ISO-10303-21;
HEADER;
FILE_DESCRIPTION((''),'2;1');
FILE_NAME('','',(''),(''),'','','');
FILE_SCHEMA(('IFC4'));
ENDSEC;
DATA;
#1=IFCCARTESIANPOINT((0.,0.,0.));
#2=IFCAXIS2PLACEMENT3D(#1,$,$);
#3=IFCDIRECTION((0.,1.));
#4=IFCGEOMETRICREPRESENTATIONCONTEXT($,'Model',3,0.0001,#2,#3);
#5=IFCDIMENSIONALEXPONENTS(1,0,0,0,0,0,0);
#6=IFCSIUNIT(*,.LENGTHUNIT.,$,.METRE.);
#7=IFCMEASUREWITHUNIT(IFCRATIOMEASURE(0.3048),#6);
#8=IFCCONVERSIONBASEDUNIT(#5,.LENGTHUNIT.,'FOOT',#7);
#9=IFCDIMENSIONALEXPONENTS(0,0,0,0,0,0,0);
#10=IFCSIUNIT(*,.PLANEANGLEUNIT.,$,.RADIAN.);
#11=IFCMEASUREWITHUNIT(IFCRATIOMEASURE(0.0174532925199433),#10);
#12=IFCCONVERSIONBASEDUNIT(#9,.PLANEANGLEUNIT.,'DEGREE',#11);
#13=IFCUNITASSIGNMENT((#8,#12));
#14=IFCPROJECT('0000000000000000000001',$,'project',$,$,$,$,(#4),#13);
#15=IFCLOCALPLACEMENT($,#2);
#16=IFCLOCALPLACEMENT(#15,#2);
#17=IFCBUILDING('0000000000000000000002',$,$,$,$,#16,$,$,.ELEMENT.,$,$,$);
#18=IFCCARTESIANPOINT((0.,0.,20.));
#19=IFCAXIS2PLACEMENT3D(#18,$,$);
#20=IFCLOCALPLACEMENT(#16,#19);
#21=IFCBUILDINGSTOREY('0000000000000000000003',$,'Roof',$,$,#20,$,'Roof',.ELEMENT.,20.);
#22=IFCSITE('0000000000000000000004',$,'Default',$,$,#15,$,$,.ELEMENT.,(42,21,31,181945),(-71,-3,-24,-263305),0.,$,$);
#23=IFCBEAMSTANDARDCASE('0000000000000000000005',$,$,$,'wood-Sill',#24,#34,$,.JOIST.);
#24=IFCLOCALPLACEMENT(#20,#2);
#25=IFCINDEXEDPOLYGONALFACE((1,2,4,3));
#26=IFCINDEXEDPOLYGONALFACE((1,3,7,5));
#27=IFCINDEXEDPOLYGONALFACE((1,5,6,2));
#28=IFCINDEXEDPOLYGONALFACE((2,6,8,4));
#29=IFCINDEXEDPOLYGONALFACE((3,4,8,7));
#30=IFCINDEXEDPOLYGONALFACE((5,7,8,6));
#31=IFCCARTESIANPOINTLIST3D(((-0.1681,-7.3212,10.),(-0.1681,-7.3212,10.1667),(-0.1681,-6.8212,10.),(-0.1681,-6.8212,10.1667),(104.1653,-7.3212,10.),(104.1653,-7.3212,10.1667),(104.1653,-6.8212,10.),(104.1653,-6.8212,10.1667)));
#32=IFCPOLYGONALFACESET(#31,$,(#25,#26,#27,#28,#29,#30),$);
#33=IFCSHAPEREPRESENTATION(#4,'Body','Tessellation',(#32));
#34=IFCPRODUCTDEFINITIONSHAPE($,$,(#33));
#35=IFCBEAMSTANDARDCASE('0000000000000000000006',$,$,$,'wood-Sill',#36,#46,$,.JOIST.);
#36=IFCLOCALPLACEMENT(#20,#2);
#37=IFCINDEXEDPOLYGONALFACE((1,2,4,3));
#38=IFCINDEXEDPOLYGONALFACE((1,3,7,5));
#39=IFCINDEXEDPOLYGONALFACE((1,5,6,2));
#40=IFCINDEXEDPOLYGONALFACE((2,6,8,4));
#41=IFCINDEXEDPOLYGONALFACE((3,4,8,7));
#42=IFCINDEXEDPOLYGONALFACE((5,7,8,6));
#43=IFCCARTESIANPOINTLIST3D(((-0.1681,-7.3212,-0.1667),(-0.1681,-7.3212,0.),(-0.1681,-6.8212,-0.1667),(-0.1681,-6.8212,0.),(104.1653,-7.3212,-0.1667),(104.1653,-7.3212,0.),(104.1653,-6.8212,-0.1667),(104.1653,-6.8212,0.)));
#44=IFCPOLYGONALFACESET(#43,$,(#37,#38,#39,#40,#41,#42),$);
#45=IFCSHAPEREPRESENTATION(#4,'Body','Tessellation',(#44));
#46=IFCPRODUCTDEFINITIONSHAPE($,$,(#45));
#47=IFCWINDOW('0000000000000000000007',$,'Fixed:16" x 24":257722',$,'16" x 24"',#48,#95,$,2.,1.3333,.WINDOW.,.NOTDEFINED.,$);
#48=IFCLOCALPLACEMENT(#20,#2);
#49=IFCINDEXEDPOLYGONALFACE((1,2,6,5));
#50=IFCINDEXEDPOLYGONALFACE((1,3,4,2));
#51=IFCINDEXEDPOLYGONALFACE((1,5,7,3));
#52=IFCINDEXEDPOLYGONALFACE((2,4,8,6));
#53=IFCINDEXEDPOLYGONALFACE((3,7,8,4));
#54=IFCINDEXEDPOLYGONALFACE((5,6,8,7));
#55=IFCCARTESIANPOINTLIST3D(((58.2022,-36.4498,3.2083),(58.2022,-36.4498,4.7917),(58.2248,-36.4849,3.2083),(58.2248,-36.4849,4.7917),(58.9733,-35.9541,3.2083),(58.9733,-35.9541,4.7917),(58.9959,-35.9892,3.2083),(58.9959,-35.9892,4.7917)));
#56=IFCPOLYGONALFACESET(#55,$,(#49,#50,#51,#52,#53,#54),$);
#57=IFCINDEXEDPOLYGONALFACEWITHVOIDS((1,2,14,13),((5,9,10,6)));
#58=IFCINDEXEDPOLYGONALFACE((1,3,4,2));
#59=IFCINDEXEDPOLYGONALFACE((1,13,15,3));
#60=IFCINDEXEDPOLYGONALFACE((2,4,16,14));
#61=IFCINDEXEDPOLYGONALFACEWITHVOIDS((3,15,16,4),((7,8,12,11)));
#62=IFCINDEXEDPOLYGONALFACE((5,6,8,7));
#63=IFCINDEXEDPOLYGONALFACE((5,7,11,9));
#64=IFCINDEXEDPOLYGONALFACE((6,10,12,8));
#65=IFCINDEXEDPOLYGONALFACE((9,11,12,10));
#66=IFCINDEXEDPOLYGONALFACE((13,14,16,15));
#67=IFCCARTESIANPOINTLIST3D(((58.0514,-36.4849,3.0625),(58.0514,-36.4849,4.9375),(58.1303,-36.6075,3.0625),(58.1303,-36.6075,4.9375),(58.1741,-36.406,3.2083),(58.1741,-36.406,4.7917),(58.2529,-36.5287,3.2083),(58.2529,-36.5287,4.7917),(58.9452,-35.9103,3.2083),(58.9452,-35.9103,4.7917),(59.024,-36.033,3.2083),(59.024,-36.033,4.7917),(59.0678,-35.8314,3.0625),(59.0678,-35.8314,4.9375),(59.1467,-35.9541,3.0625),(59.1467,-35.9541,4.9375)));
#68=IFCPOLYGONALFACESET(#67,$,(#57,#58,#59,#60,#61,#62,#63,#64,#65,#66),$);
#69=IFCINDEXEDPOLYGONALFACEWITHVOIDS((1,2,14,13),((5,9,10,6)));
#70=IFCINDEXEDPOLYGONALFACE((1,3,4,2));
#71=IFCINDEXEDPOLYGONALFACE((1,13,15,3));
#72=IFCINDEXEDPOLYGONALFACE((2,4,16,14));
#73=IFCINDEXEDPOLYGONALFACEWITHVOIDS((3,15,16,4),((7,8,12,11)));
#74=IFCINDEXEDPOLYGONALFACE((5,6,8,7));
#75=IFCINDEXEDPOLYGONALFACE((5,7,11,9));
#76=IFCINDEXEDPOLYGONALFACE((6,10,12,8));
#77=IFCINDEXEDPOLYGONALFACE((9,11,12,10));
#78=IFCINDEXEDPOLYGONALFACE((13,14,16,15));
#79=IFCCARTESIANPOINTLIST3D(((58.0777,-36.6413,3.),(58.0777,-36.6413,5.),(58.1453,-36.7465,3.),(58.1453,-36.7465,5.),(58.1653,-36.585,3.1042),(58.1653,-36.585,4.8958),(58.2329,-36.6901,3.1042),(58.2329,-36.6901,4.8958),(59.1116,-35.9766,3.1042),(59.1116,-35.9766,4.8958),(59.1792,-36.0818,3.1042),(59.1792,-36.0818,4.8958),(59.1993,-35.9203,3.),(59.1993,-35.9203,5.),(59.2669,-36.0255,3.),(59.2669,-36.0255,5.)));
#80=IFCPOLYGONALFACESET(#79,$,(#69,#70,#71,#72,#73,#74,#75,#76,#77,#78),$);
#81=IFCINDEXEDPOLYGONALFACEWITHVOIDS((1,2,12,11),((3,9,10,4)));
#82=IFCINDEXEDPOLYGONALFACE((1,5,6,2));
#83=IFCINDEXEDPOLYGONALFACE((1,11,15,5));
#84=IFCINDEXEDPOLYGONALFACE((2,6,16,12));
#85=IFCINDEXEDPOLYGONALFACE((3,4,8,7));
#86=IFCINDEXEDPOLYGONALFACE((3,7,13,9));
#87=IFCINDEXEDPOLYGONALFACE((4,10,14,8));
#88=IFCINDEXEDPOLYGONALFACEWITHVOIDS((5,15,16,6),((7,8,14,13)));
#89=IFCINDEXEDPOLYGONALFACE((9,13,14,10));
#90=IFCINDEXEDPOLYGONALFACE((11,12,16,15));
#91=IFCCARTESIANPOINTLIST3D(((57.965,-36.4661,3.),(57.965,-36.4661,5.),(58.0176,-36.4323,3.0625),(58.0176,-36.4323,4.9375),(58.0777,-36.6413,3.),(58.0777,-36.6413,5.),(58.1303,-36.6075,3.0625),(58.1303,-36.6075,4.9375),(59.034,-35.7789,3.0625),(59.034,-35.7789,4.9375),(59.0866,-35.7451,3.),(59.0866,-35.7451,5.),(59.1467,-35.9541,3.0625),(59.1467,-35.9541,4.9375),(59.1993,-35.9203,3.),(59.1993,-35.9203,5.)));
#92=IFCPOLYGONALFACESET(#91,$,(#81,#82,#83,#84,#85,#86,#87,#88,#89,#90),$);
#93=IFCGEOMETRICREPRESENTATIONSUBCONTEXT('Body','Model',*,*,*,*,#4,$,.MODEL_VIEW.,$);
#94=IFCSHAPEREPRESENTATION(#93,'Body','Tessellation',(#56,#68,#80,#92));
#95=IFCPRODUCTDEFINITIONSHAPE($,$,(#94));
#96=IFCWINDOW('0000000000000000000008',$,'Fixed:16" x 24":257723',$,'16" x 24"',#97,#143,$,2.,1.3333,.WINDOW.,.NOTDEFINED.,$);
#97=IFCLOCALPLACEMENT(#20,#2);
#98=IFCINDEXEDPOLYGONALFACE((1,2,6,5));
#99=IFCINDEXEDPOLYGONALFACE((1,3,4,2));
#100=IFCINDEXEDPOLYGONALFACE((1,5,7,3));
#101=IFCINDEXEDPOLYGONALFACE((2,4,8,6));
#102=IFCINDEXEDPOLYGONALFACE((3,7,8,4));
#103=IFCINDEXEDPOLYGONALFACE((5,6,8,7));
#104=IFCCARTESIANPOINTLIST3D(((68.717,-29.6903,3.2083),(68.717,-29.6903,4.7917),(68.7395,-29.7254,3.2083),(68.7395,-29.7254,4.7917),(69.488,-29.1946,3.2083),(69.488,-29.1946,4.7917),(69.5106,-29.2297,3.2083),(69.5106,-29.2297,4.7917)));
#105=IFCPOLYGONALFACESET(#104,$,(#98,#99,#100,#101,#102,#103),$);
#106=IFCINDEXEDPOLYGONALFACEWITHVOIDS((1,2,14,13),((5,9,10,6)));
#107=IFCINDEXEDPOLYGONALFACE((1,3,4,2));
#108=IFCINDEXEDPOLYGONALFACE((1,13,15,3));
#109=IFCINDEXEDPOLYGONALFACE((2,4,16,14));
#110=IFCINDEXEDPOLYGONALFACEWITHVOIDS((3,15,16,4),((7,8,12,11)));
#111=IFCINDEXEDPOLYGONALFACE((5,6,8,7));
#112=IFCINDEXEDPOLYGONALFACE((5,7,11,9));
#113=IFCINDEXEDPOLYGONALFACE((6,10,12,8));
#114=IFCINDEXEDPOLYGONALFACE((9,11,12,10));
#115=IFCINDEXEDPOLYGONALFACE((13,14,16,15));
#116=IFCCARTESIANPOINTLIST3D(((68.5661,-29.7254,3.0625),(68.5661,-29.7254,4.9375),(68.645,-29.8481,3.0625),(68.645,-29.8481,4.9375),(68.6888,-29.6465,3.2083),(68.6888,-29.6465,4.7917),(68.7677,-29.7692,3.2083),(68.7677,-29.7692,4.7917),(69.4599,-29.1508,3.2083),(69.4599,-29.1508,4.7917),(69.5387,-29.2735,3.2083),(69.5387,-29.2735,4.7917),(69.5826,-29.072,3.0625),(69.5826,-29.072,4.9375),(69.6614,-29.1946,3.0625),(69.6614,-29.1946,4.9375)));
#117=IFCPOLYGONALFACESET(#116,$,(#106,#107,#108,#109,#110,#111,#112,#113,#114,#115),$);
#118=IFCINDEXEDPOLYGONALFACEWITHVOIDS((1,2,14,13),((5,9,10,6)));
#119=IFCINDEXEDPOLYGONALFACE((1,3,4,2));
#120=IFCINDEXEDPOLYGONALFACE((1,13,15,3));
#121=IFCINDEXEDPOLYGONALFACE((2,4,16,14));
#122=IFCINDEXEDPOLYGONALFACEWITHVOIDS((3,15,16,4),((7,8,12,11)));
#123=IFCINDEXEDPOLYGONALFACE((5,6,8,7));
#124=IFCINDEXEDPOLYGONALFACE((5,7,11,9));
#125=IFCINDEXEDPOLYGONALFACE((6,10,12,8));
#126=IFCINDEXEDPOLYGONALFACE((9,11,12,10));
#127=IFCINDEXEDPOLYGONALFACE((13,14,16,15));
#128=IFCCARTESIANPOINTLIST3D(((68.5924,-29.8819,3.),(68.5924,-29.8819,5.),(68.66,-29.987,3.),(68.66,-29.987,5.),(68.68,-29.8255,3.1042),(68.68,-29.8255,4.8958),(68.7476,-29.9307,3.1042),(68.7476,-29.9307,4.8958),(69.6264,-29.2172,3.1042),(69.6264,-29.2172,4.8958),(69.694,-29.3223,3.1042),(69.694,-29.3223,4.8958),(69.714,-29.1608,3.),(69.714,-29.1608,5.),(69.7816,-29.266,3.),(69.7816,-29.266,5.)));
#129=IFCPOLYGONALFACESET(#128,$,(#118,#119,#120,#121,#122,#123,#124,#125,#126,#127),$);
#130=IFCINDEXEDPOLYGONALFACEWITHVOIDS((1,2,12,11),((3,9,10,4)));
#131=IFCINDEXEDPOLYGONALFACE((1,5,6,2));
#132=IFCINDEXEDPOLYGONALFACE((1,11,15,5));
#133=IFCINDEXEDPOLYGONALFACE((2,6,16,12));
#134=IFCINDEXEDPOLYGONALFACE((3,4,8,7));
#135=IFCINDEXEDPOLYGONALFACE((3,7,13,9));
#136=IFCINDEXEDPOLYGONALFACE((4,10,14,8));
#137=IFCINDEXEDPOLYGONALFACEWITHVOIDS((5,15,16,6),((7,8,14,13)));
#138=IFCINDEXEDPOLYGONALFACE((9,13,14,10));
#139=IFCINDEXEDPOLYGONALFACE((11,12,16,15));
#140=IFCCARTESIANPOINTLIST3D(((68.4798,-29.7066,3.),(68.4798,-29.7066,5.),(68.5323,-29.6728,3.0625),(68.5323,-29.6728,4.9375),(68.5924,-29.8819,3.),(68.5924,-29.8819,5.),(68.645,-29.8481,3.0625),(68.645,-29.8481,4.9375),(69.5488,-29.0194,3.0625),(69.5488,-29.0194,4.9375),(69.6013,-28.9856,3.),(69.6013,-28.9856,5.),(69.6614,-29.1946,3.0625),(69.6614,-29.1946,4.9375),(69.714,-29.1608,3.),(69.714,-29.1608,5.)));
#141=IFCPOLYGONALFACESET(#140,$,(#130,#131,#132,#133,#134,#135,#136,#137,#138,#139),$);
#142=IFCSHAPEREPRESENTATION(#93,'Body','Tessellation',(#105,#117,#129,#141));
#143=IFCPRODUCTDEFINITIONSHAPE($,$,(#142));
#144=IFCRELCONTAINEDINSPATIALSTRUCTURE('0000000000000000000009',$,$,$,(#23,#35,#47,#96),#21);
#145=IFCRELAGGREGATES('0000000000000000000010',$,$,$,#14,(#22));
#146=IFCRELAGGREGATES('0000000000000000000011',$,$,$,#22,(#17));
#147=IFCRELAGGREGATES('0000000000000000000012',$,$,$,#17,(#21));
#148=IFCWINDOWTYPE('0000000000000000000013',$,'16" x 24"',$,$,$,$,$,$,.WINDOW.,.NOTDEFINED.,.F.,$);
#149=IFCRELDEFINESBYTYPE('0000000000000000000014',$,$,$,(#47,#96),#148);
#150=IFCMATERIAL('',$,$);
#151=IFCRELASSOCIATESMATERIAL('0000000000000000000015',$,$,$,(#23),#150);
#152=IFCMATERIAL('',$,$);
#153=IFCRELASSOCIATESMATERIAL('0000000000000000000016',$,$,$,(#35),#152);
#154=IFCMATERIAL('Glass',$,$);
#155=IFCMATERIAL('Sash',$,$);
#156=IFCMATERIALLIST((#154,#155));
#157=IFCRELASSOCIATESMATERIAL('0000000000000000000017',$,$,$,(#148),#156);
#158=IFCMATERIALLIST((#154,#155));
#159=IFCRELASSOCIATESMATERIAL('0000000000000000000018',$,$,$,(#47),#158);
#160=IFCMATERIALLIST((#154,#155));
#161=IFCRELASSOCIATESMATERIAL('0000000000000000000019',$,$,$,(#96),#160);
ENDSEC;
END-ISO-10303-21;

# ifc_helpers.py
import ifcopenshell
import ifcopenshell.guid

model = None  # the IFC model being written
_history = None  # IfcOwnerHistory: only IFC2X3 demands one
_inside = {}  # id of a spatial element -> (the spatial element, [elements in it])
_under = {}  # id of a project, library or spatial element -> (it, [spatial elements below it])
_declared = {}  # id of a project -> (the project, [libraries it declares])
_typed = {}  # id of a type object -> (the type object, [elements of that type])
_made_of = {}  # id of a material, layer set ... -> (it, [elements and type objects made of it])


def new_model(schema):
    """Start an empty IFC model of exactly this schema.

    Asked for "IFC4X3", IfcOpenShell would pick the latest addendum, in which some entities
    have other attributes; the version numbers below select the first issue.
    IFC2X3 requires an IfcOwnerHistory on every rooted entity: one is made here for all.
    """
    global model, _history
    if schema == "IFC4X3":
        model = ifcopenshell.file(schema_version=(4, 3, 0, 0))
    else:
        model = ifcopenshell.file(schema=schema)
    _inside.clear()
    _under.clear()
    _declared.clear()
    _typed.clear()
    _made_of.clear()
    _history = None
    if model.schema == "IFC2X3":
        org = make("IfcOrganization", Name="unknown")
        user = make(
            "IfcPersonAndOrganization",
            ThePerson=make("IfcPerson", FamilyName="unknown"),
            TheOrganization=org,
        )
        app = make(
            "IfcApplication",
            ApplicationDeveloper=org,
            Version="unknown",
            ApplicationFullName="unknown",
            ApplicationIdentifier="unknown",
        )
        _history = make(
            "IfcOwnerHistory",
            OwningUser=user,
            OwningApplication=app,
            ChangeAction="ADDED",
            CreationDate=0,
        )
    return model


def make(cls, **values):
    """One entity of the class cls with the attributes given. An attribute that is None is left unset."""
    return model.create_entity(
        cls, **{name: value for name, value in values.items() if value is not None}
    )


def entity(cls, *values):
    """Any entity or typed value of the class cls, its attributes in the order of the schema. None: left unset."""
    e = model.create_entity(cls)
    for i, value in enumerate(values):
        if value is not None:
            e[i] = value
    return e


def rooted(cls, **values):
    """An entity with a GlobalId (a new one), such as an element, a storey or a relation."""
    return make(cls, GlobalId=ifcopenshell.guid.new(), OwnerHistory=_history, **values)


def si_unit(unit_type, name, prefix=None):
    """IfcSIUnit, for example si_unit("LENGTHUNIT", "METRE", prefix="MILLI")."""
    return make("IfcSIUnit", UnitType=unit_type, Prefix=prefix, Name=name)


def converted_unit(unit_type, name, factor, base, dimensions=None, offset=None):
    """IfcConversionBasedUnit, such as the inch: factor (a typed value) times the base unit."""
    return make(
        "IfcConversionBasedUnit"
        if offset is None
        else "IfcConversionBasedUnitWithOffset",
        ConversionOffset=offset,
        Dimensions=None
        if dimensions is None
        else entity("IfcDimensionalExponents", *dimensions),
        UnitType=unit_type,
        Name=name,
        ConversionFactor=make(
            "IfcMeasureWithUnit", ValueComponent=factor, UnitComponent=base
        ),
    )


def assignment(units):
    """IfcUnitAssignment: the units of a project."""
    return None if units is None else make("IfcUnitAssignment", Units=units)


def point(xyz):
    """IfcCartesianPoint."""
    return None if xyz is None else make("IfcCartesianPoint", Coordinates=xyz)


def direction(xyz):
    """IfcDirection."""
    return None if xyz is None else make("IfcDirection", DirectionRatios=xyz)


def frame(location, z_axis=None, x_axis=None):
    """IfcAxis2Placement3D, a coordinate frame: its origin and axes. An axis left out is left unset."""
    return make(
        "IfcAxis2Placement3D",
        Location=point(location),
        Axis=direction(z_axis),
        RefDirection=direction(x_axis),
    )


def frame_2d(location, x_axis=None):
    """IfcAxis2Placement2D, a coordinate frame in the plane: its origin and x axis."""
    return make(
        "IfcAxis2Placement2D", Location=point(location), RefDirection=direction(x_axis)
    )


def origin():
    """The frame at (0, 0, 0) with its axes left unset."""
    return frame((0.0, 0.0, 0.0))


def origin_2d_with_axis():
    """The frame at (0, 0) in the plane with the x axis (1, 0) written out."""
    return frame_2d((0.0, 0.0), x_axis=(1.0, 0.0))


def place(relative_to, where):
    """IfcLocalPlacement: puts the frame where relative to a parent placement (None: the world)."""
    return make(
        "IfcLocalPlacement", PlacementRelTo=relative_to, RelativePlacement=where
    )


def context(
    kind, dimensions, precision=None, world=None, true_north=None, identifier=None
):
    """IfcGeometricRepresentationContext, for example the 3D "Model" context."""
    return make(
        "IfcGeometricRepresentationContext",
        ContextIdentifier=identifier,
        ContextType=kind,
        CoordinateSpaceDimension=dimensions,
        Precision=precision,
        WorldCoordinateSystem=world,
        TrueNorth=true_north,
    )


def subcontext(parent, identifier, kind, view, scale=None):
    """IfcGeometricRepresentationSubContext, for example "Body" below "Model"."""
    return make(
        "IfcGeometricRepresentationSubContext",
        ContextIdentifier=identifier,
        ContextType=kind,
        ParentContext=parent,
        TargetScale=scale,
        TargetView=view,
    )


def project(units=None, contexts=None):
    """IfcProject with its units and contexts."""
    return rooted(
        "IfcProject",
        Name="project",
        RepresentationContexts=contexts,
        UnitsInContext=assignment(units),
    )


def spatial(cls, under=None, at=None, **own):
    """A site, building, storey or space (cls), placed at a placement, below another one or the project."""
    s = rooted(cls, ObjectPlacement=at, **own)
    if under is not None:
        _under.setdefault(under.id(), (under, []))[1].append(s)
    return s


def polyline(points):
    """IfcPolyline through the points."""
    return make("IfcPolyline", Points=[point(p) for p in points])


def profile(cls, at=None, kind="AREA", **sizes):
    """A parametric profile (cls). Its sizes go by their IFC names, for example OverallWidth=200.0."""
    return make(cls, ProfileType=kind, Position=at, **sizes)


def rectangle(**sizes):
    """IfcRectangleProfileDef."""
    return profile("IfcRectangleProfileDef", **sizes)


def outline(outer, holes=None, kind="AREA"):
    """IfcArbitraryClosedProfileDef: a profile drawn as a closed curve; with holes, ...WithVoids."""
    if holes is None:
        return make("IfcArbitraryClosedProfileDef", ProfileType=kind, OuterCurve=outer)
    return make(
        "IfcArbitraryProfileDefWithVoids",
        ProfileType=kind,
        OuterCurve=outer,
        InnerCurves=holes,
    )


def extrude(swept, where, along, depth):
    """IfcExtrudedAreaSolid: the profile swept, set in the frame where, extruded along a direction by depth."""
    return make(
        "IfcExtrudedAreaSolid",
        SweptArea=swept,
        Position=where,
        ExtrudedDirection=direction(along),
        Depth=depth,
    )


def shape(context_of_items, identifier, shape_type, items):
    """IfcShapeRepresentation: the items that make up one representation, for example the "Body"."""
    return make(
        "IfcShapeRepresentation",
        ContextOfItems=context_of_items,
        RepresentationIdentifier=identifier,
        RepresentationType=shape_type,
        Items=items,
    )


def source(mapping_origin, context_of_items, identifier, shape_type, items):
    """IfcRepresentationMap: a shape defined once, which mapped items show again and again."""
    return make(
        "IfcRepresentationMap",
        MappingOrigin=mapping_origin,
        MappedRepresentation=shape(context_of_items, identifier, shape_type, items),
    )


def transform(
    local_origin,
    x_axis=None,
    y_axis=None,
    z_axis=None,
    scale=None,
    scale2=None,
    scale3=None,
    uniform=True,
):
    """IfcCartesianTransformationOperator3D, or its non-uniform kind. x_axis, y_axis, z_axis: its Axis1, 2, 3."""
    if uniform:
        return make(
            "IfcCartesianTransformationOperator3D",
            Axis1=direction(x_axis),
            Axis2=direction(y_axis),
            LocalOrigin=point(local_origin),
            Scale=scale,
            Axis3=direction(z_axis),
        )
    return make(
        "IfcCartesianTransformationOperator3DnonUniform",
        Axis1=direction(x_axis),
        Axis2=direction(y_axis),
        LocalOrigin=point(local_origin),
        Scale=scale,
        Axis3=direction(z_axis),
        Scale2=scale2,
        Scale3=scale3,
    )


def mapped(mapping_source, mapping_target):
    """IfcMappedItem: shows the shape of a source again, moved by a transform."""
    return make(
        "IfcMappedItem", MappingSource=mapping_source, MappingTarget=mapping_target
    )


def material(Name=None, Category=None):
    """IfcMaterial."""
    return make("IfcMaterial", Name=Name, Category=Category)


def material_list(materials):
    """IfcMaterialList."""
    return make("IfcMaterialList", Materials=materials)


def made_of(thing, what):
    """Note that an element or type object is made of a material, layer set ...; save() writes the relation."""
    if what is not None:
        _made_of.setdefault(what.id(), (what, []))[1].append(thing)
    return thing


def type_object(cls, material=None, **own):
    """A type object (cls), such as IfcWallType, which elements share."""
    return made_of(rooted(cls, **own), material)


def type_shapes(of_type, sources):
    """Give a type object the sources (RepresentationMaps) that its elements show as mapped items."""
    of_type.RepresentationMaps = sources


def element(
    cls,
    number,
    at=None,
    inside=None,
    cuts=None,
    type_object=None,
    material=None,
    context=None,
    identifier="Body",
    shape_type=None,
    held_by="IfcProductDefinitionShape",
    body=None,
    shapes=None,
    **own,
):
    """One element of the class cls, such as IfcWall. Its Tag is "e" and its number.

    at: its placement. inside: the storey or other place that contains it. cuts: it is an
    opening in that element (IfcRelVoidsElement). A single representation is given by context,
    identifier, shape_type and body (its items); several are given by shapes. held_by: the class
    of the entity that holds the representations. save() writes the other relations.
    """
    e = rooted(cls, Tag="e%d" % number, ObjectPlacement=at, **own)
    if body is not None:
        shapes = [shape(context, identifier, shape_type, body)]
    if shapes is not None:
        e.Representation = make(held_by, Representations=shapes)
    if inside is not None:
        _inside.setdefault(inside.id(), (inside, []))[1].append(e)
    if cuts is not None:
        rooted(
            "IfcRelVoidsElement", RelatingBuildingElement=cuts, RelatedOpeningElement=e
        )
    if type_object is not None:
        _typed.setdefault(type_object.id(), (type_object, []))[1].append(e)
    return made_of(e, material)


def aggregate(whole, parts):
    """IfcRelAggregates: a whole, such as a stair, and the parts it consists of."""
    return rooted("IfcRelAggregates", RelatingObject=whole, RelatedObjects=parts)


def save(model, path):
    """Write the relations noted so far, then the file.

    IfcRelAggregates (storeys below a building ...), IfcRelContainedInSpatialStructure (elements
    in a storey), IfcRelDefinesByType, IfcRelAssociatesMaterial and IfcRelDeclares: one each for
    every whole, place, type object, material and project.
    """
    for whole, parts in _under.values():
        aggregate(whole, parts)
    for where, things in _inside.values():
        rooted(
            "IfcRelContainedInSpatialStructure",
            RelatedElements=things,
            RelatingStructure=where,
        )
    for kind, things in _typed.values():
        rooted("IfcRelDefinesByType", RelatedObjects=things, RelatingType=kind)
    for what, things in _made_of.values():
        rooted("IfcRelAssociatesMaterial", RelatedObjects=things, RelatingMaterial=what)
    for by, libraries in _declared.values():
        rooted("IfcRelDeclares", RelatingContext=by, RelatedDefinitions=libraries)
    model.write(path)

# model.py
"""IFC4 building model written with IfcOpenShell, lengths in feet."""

from ifc_helpers import new_model, entity, si_unit, converted_unit, direction, frame, origin, origin_2d_with_axis, place, context, subcontext, project, spatial, polyline, rectangle, outline, extrude, source, transform, mapped, material, material_list, type_object, type_shapes, element, save


model = new_model("IFC4")

# Units and contexts
model_context = context("Model", 3, precision=0.0001, world=origin(), true_north=direction((0.0, 1.0)))
body_context = subcontext(model_context, "Body", "Model", "MODEL_VIEW")
ifc_project = project(units=[converted_unit("LENGTHUNIT", "FOOT", entity("IfcRatioMeasure", 0.3048), si_unit("LENGTHUNIT", "METRE"), dimensions=[1, 0, 0, 0, 0, 0, 0]), converted_unit("PLANEANGLEUNIT", "DEGREE", entity("IfcRatioMeasure", 0.0174532925199433), si_unit("PLANEANGLEUNIT", "RADIAN"), dimensions=[0, 0, 0, 0, 0, 0, 0])], contexts=[model_context])

# Site, building, storey
site_placement = place(None, origin())
site = spatial("IfcSite", under=ifc_project, at=site_placement, Name="Default", CompositionType="ELEMENT", RefLatitude=(42, 21, 31, 181945), RefLongitude=(-71, -3, -24, -263305), RefElevation=0.0)
building_placement = place(site_placement, origin())
building = spatial("IfcBuilding", under=site, at=building_placement, CompositionType="ELEMENT")
storey_placement = place(building_placement, frame((0.0, 0.0, 20.0)))
storey = spatial("IfcBuildingStorey", under=building, at=storey_placement, Name="Roof", LongName="Roof", CompositionType="ELEMENT", Elevation=20.0)

# Shared definitions
placement_1 = place(storey_placement, frame((104.1653, -7.0712, 0.0), z_axis=(0.0, 0.0, 1.0), x_axis=(-1.0, 0.0, 0.0)))

# Beams
ifc_material_1 = material(Name="")
beam_1_placement = place(placement_1, frame((52.1667, 0.0, 10.0), z_axis=(0.0, 0.0, 1.0), x_axis=(-1.0, 0.0, 0.0)))
element("IfcBeamStandardCase", 1, at=beam_1_placement, inside=storey, material=ifc_material_1, ObjectType="wood-Sill", PredefinedType="JOIST", context=model_context, shape_type="SweptSolid", body=[
    extrude(rectangle(XDim=104.3334, YDim=0.5), origin(), (0.0, 0.0, 1.0), 0.1667),
])
ifc_material_2 = material(Name="")
beam_2_placement = place(placement_1, frame((52.1667, 0.0, -0.1667), z_axis=(0.0, 0.0, 1.0), x_axis=(-1.0, 0.0, 0.0)))
element("IfcBeamStandardCase", 2, at=beam_2_placement, inside=storey, material=ifc_material_2, ObjectType="wood-Sill", PredefinedType="JOIST", context=model_context, shape_type="SweptSolid", body=[
    extrude(rectangle(XDim=104.3334, YDim=0.5), origin(), (0.0, 0.0, 1.0), 0.1667),
])

# Windows
ifc_material_3 = material(Name="Glass")
ifc_material_4 = material(Name="Sash")
ifc_material_list_1 = material_list([ifc_material_3, ifc_material_4])
ifc_material_list_2 = material_list([ifc_material_3, ifc_material_4])
window_type = type_object("IfcWindowType", Name="16\" x 24\"", ParameterTakesPrecedence=False, PartitioningType="NOTDEFINED", PredefinedType="WINDOW", material=ifc_material_list_2)
shared_shape = source(origin(), body_context, "Body", "SweptSolid", [
    extrude(rectangle(XDim=0.0417, YDim=0.9167, at=origin_2d_with_axis()), frame((0.6667, 0.1979, 0.2083), z_axis=(0.0, 0.0, 1.0), x_axis=(0.0, 1.0, 0.0)), (0.0, 0.0, 1.0), 1.5833),
    extrude(outline(polyline([(-0.6042, -0.9375), (0.6042, -0.9375), (0.6042, 0.9375), (-0.6042, 0.9375), (-0.6042, -0.9375)]), holes=[polyline([(-0.4583, -0.7917), (-0.4583, 0.7917), (0.4583, 0.7917), (0.4583, -0.7917), (-0.4583, -0.7917)])]), frame((0.6667, 0.125, 1.0), z_axis=(0.0, 1.0, 0.0), x_axis=(1.0, 0.0, 0.0)), (0.0, 0.0, 1.0), 0.1458),
    extrude(outline(polyline([(-0.6667, -1.0), (0.6667, -1.0), (0.6667, 1.0), (-0.6667, 1.0), (-0.6667, -1.0)]), holes=[polyline([(-0.5625, -0.8958), (-0.5625, 0.8958), (0.5625, 0.8958), (0.5625, -0.8958), (-0.5625, -0.8958)])]), frame((0.6667, 0.0, 1.0), z_axis=(0.0, 1.0, 0.0), x_axis=(1.0, 0.0, 0.0)), (0.0, 0.0, 1.0), 0.125),
    extrude(outline(polyline([(-1.0, -0.6667), (1.0, -0.6667), (1.0, 0.6667), (-1.0, 0.6667), (-1.0, -0.6667)]), holes=[polyline([(-0.9375, -0.6042), (-0.9375, 0.6042), (0.9375, 0.6042), (0.9375, -0.6042), (-0.9375, -0.6042)])]), frame((0.6667, 0.125, 1.0), z_axis=(0.0, 1.0, 0.0), x_axis=(0.0, 0.0, -1.0)), (0.0, 0.0, 1.0), 0.2083),
])
type_shapes(window_type, [shared_shape])
placement_2 = place(storey_placement, frame((103.9574, -7.0977, 0.0), z_axis=(0.0, 0.0, 1.0), x_axis=(-0.841178, -0.540758, 0.0)))
placement_3 = place(placement_2, frame((54.569, 0.1667, 3.0)))
window_1_placement = place(placement_3, frame((0.0, 0.0, 0.0), z_axis=(0.0, 0.0, 1.0), x_axis=(-1.0, 0.0, 0.0)))
element("IfcWindow", 3, at=window_1_placement, inside=storey, type_object=window_type, material=ifc_material_list_1, Name="Fixed:16\" x 24\":257722", ObjectType="16\" x 24\"", OverallHeight=2.0, OverallWidth=1.3333, PartitioningType="NOTDEFINED", PredefinedType="WINDOW", context=body_context, shape_type="MappedRepresentation", body=[
    mapped(shared_shape, transform((0.0, 0.0, 0.0), scale=1.0)),
])
ifc_material_list_3 = material_list([ifc_material_3, ifc_material_4])
placement_4 = place(placement_2, frame((42.069, 0.1667, 3.0)))
window_2_placement = place(placement_4, frame((0.0, 0.0, 0.0), z_axis=(0.0, 0.0, 1.0), x_axis=(-1.0, 0.0, 0.0)))
element("IfcWindow", 4, at=window_2_placement, inside=storey, type_object=window_type, material=ifc_material_list_3, Name="Fixed:16\" x 24\":257723", ObjectType="16\" x 24\"", OverallHeight=2.0, OverallWidth=1.3333, PartitioningType="NOTDEFINED", PredefinedType="WINDOW", context=body_context, shape_type="MappedRepresentation", body=[
    mapped(shared_shape, transform((0.0, 0.0, 0.0), scale=1.0)),
])

save(model, "model.ifc")
